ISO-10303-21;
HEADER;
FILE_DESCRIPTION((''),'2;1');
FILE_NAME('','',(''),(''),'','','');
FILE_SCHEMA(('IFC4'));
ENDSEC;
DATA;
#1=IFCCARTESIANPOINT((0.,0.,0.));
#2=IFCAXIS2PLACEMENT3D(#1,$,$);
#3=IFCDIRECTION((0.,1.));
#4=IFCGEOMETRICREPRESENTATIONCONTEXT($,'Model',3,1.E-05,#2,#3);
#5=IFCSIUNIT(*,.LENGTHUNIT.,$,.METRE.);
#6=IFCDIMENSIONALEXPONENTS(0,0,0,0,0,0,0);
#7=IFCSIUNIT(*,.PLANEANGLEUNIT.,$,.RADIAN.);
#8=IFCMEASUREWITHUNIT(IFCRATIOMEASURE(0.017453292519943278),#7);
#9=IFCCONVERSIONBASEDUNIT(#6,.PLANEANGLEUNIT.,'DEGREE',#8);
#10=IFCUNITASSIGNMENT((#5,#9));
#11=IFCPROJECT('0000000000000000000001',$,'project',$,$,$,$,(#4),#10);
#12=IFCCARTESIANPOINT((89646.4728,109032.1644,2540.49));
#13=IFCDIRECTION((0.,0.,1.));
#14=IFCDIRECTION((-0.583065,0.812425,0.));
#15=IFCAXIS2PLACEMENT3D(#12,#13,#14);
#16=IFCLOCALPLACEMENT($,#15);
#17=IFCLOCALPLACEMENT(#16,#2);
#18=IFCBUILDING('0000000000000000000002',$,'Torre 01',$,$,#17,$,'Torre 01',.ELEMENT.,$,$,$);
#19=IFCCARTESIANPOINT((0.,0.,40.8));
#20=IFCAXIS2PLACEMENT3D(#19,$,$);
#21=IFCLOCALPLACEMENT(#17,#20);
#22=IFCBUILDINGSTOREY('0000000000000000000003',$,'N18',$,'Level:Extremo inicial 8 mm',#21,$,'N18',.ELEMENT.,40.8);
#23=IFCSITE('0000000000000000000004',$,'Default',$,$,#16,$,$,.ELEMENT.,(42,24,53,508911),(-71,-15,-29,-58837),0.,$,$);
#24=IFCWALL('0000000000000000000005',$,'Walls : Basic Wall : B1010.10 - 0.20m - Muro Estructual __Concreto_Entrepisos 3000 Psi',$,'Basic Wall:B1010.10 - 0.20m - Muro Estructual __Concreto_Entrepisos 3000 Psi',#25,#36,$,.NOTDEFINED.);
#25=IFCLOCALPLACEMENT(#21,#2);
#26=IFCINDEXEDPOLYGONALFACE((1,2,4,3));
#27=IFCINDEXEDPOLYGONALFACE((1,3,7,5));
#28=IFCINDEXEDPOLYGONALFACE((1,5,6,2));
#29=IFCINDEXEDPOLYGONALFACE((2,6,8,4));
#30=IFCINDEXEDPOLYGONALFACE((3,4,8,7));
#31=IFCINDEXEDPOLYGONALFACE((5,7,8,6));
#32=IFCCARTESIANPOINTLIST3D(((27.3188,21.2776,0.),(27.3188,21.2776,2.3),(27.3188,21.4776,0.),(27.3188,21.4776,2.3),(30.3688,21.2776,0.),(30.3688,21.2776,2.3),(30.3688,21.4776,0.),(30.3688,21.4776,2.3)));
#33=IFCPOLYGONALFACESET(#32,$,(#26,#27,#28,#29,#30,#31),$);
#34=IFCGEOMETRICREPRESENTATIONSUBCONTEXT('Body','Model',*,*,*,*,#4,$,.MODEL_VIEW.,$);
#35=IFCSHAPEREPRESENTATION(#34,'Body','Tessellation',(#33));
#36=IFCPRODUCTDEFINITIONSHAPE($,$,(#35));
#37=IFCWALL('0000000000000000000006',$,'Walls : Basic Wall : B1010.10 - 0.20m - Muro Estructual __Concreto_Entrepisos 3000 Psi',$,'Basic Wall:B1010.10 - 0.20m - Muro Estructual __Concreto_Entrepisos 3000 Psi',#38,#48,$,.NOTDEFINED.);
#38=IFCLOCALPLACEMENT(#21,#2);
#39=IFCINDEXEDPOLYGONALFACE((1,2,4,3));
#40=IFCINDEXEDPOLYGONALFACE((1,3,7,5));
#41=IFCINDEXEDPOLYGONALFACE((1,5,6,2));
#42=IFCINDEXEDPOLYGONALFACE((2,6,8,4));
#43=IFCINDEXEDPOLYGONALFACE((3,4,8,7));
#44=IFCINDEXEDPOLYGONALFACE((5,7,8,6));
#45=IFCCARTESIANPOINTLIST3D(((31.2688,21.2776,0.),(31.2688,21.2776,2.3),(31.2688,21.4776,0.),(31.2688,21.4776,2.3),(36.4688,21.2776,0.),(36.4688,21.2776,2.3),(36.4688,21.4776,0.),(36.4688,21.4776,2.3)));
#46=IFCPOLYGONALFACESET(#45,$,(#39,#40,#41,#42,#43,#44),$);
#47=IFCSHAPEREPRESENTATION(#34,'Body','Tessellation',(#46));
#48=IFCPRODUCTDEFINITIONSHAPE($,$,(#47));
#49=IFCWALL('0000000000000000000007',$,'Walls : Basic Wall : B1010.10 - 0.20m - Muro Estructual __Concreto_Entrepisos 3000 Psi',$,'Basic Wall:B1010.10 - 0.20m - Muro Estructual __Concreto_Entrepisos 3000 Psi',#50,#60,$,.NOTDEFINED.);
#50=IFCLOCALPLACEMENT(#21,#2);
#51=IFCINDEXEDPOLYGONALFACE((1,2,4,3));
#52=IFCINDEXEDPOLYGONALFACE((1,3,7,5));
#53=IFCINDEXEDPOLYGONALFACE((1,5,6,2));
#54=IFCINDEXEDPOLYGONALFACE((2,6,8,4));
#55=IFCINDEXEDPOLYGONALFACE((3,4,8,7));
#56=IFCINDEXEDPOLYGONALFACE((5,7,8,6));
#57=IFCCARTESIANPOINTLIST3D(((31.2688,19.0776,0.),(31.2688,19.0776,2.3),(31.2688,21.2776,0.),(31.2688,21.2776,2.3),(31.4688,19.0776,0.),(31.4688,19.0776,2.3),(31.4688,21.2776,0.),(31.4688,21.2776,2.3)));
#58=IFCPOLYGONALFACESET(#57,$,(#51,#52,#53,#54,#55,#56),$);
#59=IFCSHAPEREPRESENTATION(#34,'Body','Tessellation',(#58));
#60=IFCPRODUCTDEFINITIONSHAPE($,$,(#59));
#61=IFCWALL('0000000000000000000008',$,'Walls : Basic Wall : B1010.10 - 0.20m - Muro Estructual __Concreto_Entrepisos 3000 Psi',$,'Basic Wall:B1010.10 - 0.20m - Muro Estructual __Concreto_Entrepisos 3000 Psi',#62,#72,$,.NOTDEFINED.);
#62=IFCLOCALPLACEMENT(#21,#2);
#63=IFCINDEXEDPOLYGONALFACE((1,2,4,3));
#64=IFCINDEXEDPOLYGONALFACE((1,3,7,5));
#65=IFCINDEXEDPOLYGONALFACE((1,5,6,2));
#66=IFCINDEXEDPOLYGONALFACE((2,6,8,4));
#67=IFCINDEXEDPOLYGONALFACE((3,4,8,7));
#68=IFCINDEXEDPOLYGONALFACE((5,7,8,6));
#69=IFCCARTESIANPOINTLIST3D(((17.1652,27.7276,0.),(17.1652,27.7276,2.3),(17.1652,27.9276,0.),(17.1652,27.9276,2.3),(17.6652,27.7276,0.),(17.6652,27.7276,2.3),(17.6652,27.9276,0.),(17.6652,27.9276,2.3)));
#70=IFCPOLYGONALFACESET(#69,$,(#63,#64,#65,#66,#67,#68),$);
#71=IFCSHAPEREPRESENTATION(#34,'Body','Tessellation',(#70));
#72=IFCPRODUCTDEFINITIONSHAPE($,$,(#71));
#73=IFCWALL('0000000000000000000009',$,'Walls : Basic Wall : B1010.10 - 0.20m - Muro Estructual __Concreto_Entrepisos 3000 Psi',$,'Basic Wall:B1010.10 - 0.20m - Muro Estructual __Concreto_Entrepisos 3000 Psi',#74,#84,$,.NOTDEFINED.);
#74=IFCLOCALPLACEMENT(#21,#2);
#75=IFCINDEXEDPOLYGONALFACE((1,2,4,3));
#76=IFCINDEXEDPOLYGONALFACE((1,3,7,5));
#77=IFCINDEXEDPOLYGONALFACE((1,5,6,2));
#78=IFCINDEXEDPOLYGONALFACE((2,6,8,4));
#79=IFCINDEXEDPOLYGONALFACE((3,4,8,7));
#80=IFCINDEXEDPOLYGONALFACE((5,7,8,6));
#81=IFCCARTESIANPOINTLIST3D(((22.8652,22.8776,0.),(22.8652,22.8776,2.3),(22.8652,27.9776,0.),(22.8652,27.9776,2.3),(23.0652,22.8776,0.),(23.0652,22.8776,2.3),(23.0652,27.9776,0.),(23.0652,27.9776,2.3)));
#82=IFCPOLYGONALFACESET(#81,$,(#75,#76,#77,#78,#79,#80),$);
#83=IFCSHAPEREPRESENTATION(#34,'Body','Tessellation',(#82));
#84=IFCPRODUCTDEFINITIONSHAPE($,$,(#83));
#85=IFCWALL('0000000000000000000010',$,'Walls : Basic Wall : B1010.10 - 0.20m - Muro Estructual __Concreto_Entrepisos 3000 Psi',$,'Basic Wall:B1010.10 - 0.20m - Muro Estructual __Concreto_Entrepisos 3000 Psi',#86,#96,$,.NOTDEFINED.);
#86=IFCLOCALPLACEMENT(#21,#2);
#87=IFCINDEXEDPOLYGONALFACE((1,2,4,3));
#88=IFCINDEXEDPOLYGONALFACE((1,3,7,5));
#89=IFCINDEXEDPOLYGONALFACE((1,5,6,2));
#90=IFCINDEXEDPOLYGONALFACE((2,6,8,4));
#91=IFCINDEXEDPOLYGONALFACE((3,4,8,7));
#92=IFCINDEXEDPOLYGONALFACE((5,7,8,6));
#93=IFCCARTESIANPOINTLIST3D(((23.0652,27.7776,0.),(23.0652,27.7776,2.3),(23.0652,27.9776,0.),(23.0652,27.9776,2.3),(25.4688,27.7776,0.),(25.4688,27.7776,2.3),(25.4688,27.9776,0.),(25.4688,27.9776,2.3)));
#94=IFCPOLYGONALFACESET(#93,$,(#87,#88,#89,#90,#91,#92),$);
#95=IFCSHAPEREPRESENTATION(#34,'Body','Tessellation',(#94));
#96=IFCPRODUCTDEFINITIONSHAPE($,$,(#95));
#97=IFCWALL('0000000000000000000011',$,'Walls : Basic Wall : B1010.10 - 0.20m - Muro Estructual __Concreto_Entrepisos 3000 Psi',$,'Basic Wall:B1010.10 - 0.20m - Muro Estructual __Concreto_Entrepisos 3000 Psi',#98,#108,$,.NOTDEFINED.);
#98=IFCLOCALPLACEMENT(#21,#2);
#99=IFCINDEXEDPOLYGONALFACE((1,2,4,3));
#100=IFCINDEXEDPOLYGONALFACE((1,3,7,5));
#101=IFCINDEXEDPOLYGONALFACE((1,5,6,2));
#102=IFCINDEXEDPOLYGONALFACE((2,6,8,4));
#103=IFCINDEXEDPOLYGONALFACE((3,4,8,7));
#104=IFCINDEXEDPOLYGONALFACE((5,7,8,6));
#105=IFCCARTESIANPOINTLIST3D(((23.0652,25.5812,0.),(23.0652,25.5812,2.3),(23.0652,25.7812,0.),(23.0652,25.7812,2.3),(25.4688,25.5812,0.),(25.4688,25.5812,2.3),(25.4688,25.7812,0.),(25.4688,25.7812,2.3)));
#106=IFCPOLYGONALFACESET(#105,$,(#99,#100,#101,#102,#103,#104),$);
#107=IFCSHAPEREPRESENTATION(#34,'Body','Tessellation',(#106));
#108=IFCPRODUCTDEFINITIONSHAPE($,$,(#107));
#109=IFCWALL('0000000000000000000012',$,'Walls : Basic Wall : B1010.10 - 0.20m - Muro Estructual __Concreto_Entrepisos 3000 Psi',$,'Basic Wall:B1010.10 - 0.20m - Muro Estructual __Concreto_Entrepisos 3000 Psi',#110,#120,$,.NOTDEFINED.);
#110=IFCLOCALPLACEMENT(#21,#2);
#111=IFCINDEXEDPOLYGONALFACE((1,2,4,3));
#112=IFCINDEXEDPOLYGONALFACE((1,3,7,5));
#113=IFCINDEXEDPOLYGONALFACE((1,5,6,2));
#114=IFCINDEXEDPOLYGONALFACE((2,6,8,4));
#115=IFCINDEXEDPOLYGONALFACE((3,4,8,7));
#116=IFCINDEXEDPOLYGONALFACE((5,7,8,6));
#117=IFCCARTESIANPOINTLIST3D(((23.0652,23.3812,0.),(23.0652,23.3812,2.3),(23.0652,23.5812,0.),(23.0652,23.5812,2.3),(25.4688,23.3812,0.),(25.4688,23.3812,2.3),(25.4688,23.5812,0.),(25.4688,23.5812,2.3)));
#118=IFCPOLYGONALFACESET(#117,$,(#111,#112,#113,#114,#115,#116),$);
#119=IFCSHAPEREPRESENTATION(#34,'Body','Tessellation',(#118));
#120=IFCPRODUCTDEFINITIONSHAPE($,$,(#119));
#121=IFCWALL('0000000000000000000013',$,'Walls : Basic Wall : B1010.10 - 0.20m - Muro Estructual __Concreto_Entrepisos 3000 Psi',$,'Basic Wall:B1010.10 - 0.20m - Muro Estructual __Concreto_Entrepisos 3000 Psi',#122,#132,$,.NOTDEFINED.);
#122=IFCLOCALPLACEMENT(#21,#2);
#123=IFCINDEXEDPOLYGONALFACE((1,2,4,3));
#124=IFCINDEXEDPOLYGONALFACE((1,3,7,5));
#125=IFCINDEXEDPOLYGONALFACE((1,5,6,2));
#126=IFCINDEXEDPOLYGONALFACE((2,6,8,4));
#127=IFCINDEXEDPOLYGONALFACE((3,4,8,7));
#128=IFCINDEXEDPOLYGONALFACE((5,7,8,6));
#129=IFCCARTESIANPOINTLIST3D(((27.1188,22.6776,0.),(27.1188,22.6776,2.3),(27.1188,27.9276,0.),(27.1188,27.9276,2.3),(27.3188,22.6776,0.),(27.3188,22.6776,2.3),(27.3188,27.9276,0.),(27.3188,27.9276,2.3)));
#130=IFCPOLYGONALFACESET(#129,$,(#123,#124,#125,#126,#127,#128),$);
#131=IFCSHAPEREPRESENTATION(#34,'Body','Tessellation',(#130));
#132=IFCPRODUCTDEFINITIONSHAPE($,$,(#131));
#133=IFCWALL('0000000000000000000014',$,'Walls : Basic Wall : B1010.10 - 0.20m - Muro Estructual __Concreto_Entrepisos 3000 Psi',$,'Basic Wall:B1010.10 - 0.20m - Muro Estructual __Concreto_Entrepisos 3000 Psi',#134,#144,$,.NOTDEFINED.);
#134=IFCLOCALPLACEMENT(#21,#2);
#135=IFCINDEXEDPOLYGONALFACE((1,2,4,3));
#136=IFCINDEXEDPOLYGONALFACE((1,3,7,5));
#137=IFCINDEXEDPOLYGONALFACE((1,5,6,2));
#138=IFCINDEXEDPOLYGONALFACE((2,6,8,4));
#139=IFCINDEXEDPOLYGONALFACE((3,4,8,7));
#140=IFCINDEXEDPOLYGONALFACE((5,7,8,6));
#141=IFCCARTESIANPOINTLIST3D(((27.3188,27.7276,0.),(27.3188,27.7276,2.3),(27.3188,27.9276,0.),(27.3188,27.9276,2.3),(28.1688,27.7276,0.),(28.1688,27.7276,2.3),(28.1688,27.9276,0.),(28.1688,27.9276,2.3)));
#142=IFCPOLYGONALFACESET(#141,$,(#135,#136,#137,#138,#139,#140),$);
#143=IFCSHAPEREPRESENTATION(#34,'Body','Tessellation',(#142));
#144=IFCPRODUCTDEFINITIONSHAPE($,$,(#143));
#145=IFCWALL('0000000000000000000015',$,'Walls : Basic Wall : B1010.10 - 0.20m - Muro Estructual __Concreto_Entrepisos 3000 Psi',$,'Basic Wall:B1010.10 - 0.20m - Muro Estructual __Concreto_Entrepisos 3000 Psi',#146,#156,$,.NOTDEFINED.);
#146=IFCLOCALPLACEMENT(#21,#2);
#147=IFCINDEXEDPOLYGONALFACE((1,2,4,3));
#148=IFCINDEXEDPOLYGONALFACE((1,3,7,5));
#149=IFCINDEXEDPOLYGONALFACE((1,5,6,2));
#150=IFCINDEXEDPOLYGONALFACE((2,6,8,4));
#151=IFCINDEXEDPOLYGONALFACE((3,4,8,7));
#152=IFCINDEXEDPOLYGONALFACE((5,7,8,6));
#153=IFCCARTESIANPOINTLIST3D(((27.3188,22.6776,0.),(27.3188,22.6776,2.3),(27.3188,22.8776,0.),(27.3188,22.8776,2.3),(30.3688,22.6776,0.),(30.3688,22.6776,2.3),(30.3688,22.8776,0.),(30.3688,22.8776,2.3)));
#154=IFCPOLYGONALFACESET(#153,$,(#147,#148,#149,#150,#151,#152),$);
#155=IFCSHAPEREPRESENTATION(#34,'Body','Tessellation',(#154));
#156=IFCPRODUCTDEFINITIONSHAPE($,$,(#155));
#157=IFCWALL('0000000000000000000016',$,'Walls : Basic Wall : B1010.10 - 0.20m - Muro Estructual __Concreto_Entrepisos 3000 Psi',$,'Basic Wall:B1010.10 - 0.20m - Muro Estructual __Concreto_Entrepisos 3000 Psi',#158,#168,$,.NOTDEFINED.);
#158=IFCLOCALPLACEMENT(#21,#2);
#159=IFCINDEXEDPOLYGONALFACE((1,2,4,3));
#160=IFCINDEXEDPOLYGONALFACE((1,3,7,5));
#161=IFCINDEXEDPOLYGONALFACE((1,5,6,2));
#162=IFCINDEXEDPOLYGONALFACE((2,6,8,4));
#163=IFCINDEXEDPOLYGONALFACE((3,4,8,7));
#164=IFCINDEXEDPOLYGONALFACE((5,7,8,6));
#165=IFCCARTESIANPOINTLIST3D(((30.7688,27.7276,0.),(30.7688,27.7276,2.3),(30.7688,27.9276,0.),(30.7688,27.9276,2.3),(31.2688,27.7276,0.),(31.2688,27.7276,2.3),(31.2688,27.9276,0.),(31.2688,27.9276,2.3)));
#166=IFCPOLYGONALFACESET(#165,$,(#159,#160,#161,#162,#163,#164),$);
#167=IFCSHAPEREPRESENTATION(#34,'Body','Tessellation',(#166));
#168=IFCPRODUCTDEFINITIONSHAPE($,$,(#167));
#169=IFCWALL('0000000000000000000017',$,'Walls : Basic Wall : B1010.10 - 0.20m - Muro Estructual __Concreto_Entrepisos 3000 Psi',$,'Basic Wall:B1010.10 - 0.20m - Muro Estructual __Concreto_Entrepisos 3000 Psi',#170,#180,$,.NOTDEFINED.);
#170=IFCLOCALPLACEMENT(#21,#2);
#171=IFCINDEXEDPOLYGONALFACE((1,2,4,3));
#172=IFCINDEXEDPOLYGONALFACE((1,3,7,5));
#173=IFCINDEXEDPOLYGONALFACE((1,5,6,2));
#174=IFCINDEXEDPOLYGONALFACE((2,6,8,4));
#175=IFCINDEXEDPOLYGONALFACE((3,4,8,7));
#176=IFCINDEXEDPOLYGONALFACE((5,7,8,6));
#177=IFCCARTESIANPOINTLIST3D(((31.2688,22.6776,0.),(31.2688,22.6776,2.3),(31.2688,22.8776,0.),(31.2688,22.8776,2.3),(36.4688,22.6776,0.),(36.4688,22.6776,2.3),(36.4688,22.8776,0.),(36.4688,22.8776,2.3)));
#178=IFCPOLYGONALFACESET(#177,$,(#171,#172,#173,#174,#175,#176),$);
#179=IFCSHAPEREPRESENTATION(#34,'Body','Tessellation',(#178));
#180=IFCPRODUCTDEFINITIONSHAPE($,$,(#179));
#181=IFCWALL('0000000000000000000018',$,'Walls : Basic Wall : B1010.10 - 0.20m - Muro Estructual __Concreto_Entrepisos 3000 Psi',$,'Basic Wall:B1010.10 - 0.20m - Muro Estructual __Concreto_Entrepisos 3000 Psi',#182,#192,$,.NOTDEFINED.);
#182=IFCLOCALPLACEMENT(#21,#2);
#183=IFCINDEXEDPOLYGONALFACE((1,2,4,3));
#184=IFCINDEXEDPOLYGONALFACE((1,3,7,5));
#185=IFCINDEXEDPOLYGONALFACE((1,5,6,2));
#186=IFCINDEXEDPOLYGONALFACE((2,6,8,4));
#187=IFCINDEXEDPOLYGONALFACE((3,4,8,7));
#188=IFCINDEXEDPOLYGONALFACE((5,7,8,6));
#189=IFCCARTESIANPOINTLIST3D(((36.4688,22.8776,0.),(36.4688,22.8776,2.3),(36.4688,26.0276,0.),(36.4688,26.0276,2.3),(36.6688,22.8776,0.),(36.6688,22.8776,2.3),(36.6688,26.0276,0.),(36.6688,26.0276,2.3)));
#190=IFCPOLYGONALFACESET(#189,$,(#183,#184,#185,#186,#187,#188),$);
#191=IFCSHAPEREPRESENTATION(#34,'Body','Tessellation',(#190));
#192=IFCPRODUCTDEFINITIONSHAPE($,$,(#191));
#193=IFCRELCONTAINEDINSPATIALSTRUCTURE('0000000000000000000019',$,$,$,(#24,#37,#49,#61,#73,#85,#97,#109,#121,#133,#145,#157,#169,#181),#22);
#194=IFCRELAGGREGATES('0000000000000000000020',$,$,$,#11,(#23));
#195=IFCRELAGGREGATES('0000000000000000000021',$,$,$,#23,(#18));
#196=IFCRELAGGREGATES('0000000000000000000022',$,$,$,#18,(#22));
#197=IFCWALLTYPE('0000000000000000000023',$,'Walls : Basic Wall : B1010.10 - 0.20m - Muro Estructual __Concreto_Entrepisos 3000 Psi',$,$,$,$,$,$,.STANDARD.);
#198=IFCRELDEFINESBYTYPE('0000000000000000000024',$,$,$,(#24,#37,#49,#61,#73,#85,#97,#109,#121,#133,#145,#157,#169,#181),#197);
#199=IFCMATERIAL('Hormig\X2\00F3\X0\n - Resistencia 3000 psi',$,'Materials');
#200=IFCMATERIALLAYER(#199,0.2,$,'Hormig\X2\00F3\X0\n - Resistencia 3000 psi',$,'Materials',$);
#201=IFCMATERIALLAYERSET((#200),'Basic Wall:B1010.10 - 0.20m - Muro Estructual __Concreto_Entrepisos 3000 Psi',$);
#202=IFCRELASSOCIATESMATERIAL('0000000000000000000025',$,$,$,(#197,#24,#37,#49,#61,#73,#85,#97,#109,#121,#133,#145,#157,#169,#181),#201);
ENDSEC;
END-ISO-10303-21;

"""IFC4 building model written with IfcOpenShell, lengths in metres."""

from ifc_helpers import new_model, entity, si_unit, converted_unit, direction, frame, frame_2d, origin, place, context, subcontext, project, spatial, rectangle, extrude, material, layer, layer_set, layer_usage, type_object, element, save


model = new_model("IFC4")

# Units and contexts
model_context = context("Model", 3, precision=1e-05, world=origin(), true_north=direction((0.0, 1.0)))
body_context = subcontext(model_context, "Body", "Model", "MODEL_VIEW")
ifc_project = project(units=[si_unit("LENGTHUNIT", "METRE"), converted_unit("PLANEANGLEUNIT", "DEGREE", entity("IfcRatioMeasure", 0.017453292519943278), si_unit("PLANEANGLEUNIT", "RADIAN"), dimensions=[0, 0, 0, 0, 0, 0, 0])], contexts=[model_context])

# Site, building, storey
site_placement = place(None, frame((89646.4728, 109032.1644, 2540.49), z_axis=(0.0, 0.0, 1.0), x_axis=(-0.583065, 0.812425, 0.0)))
site = spatial("IfcSite", under=ifc_project, at=site_placement, Name="Default", CompositionType="ELEMENT", RefLatitude=(42, 24, 53, 508911), RefLongitude=(-71, -15, -29, -58837), RefElevation=0.0)
building_placement = place(site_placement, origin())
building = spatial("IfcBuilding", under=site, at=building_placement, Name="Torre 01", LongName="Torre 01", CompositionType="ELEMENT")
storey_placement = place(building_placement, frame((0.0, 0.0, 40.8)))
storey = spatial("IfcBuildingStorey", under=building, at=storey_placement, Name="N18", ObjectType="Level:Extremo inicial 8 mm", LongName="N18", CompositionType="ELEMENT", Elevation=40.8)

# Walls
ifc_material = material(Name="Hormigón - Resistencia 3000 psi", Category="Materials")
ifc_layer_1 = layer(ifc_material, 0.2, Name="Hormigón - Resistencia 3000 psi", Category="Materials")
ifc_layer_set_1 = layer_set([ifc_layer_1], Name="Basic Wall:B1010.10 - 0.20m - Muro Estructual __Concreto_Entrepisos 3000 Psi")
ifc_layer_usage_1 = layer_usage(ifc_layer_set_1, "AXIS2", "NEGATIVE", 0.1)
wall_type_1 = type_object("IfcWallType", Name="Walls : Basic Wall : B1010.10 - 0.20m - Muro Estructual __Concreto_Entrepisos 3000 Psi", PredefinedType="STANDARD", material=ifc_layer_set_1)
wall_1_placement = place(storey_placement, frame((27.3188, 21.3776, 0.0)))
element("IfcWall", 1, at=wall_1_placement, inside=storey, type_object=wall_type_1, material=ifc_layer_usage_1, Name="Walls : Basic Wall : B1010.10 - 0.20m - Muro Estructual __Concreto_Entrepisos 3000 Psi", ObjectType="Basic Wall:B1010.10 - 0.20m - Muro Estructual __Concreto_Entrepisos 3000 Psi", PredefinedType="NOTDEFINED", context=body_context, shape_type="SweptSolid", body=[
    extrude(rectangle(XDim=3.05, YDim=0.2, at=frame_2d((1.525, 0.0), x_axis=(-1.0, 0.0))), origin(), (0.0, 0.0, 1.0), 2.3),
])
ifc_layer_usage_2 = layer_usage(ifc_layer_set_1, "AXIS2", "NEGATIVE", 0.1)
wall_2_placement = place(storey_placement, frame((31.2688, 21.3776, 0.0)))
element("IfcWall", 2, at=wall_2_placement, inside=storey, type_object=wall_type_1, material=ifc_layer_usage_2, Name="Walls : Basic Wall : B1010.10 - 0.20m - Muro Estructual __Concreto_Entrepisos 3000 Psi", ObjectType="Basic Wall:B1010.10 - 0.20m - Muro Estructual __Concreto_Entrepisos 3000 Psi", PredefinedType="NOTDEFINED", context=body_context, shape_type="SweptSolid", body=[
    extrude(rectangle(XDim=5.2, YDim=0.2, at=frame_2d((2.6, 0.0), x_axis=(-1.0, 0.0))), origin(), (0.0, 0.0, 1.0), 2.3),
])
ifc_layer_usage_3 = layer_usage(ifc_layer_set_1, "AXIS2", "NEGATIVE", 0.1)
wall_3_placement = place(storey_placement, frame((31.3688, 21.2776, 0.0), z_axis=(0.0, 0.0, 1.0), x_axis=(0.0, -1.0, 0.0)))
element("IfcWall", 3, at=wall_3_placement, inside=storey, type_object=wall_type_1, material=ifc_layer_usage_3, Name="Walls : Basic Wall : B1010.10 - 0.20m - Muro Estructual __Concreto_Entrepisos 3000 Psi", ObjectType="Basic Wall:B1010.10 - 0.20m - Muro Estructual __Concreto_Entrepisos 3000 Psi", PredefinedType="NOTDEFINED", context=body_context, shape_type="SweptSolid", body=[
    extrude(rectangle(XDim=2.2, YDim=0.2, at=frame_2d((1.1, 0.0), x_axis=(-1.0, 0.0))), origin(), (0.0, 0.0, 1.0), 2.3),
])
ifc_layer_usage_4 = layer_usage(ifc_layer_set_1, "AXIS2", "POSITIVE", -0.1)
wall_4_placement = place(storey_placement, frame((17.6652, 27.8276, 0.0), z_axis=(0.0, 0.0, 1.0), x_axis=(-1.0, 0.0, 0.0)))
element("IfcWall", 4, at=wall_4_placement, inside=storey, type_object=wall_type_1, material=ifc_layer_usage_4, Name="Walls : Basic Wall : B1010.10 - 0.20m - Muro Estructual __Concreto_Entrepisos 3000 Psi", ObjectType="Basic Wall:B1010.10 - 0.20m - Muro Estructual __Concreto_Entrepisos 3000 Psi", PredefinedType="NOTDEFINED", context=body_context, shape_type="SweptSolid", body=[
    extrude(rectangle(XDim=0.5, YDim=0.2, at=frame_2d((0.25, 0.0), x_axis=(-1.0, 0.0))), origin(), (0.0, 0.0, 1.0), 2.3),
])
ifc_layer_usage_5 = layer_usage(ifc_layer_set_1, "AXIS2", "NEGATIVE", 0.1)
wall_5_placement = place(storey_placement, frame((22.9652, 22.8776, 0.0), z_axis=(0.0, 0.0, 1.0), x_axis=(0.0, 1.0, 0.0)))
element("IfcWall", 5, at=wall_5_placement, inside=storey, type_object=wall_type_1, material=ifc_layer_usage_5, Name="Walls : Basic Wall : B1010.10 - 0.20m - Muro Estructual __Concreto_Entrepisos 3000 Psi", ObjectType="Basic Wall:B1010.10 - 0.20m - Muro Estructual __Concreto_Entrepisos 3000 Psi", PredefinedType="NOTDEFINED", context=body_context, shape_type="SweptSolid", body=[
    extrude(rectangle(XDim=5.1, YDim=0.2, at=frame_2d((2.55, 0.0), x_axis=(-1.0, 0.0))), origin(), (0.0, 0.0, 1.0), 2.3),
])
ifc_layer_usage_6 = layer_usage(ifc_layer_set_1, "AXIS2", "NEGATIVE", 0.1)
wall_6_placement = place(storey_placement, frame((23.0652, 27.8776, 0.0)))
element("IfcWall", 6, at=wall_6_placement, inside=storey, type_object=wall_type_1, material=ifc_layer_usage_6, Name="Walls : Basic Wall : B1010.10 - 0.20m - Muro Estructual __Concreto_Entrepisos 3000 Psi", ObjectType="Basic Wall:B1010.10 - 0.20m - Muro Estructual __Concreto_Entrepisos 3000 Psi", PredefinedType="NOTDEFINED", context=body_context, shape_type="SweptSolid", body=[
    extrude(rectangle(XDim=2.4037, YDim=0.2, at=frame_2d((1.2018, 0.0), x_axis=(-1.0, 0.0))), origin(), (0.0, 0.0, 1.0), 2.3),
])
ifc_layer_usage_7 = layer_usage(ifc_layer_set_1, "AXIS2", "NEGATIVE", 0.1)
wall_7_placement = place(storey_placement, frame((23.0652, 25.6812, 0.0)))
element("IfcWall", 7, at=wall_7_placement, inside=storey, type_object=wall_type_1, material=ifc_layer_usage_7, Name="Walls : Basic Wall : B1010.10 - 0.20m - Muro Estructual __Concreto_Entrepisos 3000 Psi", ObjectType="Basic Wall:B1010.10 - 0.20m - Muro Estructual __Concreto_Entrepisos 3000 Psi", PredefinedType="NOTDEFINED", context=body_context, shape_type="SweptSolid", body=[
    extrude(rectangle(XDim=2.4037, YDim=0.2, at=frame_2d((1.2018, 0.0), x_axis=(-1.0, 0.0))), origin(), (0.0, 0.0, 1.0), 2.3),
])
ifc_layer_usage_8 = layer_usage(ifc_layer_set_1, "AXIS2", "NEGATIVE", 0.1)
wall_8_placement = place(storey_placement, frame((23.0652, 23.4812, 0.0)))
element("IfcWall", 8, at=wall_8_placement, inside=storey, type_object=wall_type_1, material=ifc_layer_usage_8, Name="Walls : Basic Wall : B1010.10 - 0.20m - Muro Estructual __Concreto_Entrepisos 3000 Psi", ObjectType="Basic Wall:B1010.10 - 0.20m - Muro Estructual __Concreto_Entrepisos 3000 Psi", PredefinedType="NOTDEFINED", context=body_context, shape_type="SweptSolid", body=[
    extrude(rectangle(XDim=2.4037, YDim=0.2, at=frame_2d((1.2018, 0.0), x_axis=(-1.0, 0.0))), origin(), (0.0, 0.0, 1.0), 2.3),
])
ifc_layer_usage_9 = layer_usage(ifc_layer_set_1, "AXIS2", "POSITIVE", -0.1)
wall_9_placement = place(storey_placement, frame((27.2188, 27.9276, 0.0), z_axis=(0.0, 0.0, 1.0), x_axis=(0.0, -1.0, 0.0)))
element("IfcWall", 9, at=wall_9_placement, inside=storey, type_object=wall_type_1, material=ifc_layer_usage_9, Name="Walls : Basic Wall : B1010.10 - 0.20m - Muro Estructual __Concreto_Entrepisos 3000 Psi", ObjectType="Basic Wall:B1010.10 - 0.20m - Muro Estructual __Concreto_Entrepisos 3000 Psi", PredefinedType="NOTDEFINED", context=body_context, shape_type="SweptSolid", body=[
    extrude(rectangle(XDim=5.25, YDim=0.2, at=frame_2d((2.625, 0.0), x_axis=(-1.0, 0.0))), origin(), (0.0, 0.0, 1.0), 2.3),
])
ifc_layer_usage_10 = layer_usage(ifc_layer_set_1, "AXIS2", "POSITIVE", -0.1)
wall_10_placement = place(storey_placement, frame((27.3188, 27.8276, 0.0)))
element("IfcWall", 10, at=wall_10_placement, inside=storey, type_object=wall_type_1, material=ifc_layer_usage_10, Name="Walls : Basic Wall : B1010.10 - 0.20m - Muro Estructual __Concreto_Entrepisos 3000 Psi", ObjectType="Basic Wall:B1010.10 - 0.20m - Muro Estructual __Concreto_Entrepisos 3000 Psi", PredefinedType="NOTDEFINED", context=body_context, shape_type="SweptSolid", body=[
    extrude(rectangle(XDim=0.85, YDim=0.2, at=frame_2d((0.425, 0.0), x_axis=(-1.0, 0.0))), origin(), (0.0, 0.0, 1.0), 2.3),
])
ifc_layer_usage_11 = layer_usage(ifc_layer_set_1, "AXIS2", "POSITIVE", -0.1)
wall_11_placement = place(storey_placement, frame((27.3188, 22.7776, 0.0)))
element("IfcWall", 11, at=wall_11_placement, inside=storey, type_object=wall_type_1, material=ifc_layer_usage_11, Name="Walls : Basic Wall : B1010.10 - 0.20m - Muro Estructual __Concreto_Entrepisos 3000 Psi", ObjectType="Basic Wall:B1010.10 - 0.20m - Muro Estructual __Concreto_Entrepisos 3000 Psi", PredefinedType="NOTDEFINED", context=body_context, shape_type="SweptSolid", body=[
    extrude(rectangle(XDim=3.05, YDim=0.2, at=frame_2d((1.525, 0.0), x_axis=(-1.0, 0.0))), origin(), (0.0, 0.0, 1.0), 2.3),
])
ifc_layer_usage_12 = layer_usage(ifc_layer_set_1, "AXIS2", "POSITIVE", -0.1)
wall_12_placement = place(storey_placement, frame((30.7688, 27.8276, 0.0)))
element("IfcWall", 12, at=wall_12_placement, inside=storey, type_object=wall_type_1, material=ifc_layer_usage_12, Name="Walls : Basic Wall : B1010.10 - 0.20m - Muro Estructual __Concreto_Entrepisos 3000 Psi", ObjectType="Basic Wall:B1010.10 - 0.20m - Muro Estructual __Concreto_Entrepisos 3000 Psi", PredefinedType="NOTDEFINED", context=body_context, shape_type="SweptSolid", body=[
    extrude(rectangle(XDim=0.5, YDim=0.2, at=frame_2d((0.25, 0.0), x_axis=(-1.0, 0.0))), origin(), (0.0, 0.0, 1.0), 2.3),
])
ifc_layer_usage_13 = layer_usage(ifc_layer_set_1, "AXIS2", "POSITIVE", -0.1)
wall_13_placement = place(storey_placement, frame((31.2688, 22.7776, 0.0)))
element("IfcWall", 13, at=wall_13_placement, inside=storey, type_object=wall_type_1, material=ifc_layer_usage_13, Name="Walls : Basic Wall : B1010.10 - 0.20m - Muro Estructual __Concreto_Entrepisos 3000 Psi", ObjectType="Basic Wall:B1010.10 - 0.20m - Muro Estructual __Concreto_Entrepisos 3000 Psi", PredefinedType="NOTDEFINED", context=body_context, shape_type="SweptSolid", body=[
    extrude(rectangle(XDim=5.2, YDim=0.2, at=frame_2d((2.6, 0.0), x_axis=(-1.0, 0.0))), origin(), (0.0, 0.0, 1.0), 2.3),
])
ifc_layer_usage_14 = layer_usage(ifc_layer_set_1, "AXIS2", "POSITIVE", -0.1)
wall_14_placement = place(storey_placement, frame((36.5688, 26.0276, 0.0), z_axis=(0.0, 0.0, 1.0), x_axis=(0.0, -1.0, 0.0)))
element("IfcWall", 14, at=wall_14_placement, inside=storey, type_object=wall_type_1, material=ifc_layer_usage_14, Name="Walls : Basic Wall : B1010.10 - 0.20m - Muro Estructual __Concreto_Entrepisos 3000 Psi", ObjectType="Basic Wall:B1010.10 - 0.20m - Muro Estructual __Concreto_Entrepisos 3000 Psi", PredefinedType="NOTDEFINED", context=body_context, shape_type="SweptSolid", body=[
    extrude(rectangle(XDim=3.15, YDim=0.2, at=frame_2d((1.575, 0.0), x_axis=(-1.0, 0.0))), origin(), (0.0, 0.0, 1.0), 2.3),
])

save(model, "model.ifc")
